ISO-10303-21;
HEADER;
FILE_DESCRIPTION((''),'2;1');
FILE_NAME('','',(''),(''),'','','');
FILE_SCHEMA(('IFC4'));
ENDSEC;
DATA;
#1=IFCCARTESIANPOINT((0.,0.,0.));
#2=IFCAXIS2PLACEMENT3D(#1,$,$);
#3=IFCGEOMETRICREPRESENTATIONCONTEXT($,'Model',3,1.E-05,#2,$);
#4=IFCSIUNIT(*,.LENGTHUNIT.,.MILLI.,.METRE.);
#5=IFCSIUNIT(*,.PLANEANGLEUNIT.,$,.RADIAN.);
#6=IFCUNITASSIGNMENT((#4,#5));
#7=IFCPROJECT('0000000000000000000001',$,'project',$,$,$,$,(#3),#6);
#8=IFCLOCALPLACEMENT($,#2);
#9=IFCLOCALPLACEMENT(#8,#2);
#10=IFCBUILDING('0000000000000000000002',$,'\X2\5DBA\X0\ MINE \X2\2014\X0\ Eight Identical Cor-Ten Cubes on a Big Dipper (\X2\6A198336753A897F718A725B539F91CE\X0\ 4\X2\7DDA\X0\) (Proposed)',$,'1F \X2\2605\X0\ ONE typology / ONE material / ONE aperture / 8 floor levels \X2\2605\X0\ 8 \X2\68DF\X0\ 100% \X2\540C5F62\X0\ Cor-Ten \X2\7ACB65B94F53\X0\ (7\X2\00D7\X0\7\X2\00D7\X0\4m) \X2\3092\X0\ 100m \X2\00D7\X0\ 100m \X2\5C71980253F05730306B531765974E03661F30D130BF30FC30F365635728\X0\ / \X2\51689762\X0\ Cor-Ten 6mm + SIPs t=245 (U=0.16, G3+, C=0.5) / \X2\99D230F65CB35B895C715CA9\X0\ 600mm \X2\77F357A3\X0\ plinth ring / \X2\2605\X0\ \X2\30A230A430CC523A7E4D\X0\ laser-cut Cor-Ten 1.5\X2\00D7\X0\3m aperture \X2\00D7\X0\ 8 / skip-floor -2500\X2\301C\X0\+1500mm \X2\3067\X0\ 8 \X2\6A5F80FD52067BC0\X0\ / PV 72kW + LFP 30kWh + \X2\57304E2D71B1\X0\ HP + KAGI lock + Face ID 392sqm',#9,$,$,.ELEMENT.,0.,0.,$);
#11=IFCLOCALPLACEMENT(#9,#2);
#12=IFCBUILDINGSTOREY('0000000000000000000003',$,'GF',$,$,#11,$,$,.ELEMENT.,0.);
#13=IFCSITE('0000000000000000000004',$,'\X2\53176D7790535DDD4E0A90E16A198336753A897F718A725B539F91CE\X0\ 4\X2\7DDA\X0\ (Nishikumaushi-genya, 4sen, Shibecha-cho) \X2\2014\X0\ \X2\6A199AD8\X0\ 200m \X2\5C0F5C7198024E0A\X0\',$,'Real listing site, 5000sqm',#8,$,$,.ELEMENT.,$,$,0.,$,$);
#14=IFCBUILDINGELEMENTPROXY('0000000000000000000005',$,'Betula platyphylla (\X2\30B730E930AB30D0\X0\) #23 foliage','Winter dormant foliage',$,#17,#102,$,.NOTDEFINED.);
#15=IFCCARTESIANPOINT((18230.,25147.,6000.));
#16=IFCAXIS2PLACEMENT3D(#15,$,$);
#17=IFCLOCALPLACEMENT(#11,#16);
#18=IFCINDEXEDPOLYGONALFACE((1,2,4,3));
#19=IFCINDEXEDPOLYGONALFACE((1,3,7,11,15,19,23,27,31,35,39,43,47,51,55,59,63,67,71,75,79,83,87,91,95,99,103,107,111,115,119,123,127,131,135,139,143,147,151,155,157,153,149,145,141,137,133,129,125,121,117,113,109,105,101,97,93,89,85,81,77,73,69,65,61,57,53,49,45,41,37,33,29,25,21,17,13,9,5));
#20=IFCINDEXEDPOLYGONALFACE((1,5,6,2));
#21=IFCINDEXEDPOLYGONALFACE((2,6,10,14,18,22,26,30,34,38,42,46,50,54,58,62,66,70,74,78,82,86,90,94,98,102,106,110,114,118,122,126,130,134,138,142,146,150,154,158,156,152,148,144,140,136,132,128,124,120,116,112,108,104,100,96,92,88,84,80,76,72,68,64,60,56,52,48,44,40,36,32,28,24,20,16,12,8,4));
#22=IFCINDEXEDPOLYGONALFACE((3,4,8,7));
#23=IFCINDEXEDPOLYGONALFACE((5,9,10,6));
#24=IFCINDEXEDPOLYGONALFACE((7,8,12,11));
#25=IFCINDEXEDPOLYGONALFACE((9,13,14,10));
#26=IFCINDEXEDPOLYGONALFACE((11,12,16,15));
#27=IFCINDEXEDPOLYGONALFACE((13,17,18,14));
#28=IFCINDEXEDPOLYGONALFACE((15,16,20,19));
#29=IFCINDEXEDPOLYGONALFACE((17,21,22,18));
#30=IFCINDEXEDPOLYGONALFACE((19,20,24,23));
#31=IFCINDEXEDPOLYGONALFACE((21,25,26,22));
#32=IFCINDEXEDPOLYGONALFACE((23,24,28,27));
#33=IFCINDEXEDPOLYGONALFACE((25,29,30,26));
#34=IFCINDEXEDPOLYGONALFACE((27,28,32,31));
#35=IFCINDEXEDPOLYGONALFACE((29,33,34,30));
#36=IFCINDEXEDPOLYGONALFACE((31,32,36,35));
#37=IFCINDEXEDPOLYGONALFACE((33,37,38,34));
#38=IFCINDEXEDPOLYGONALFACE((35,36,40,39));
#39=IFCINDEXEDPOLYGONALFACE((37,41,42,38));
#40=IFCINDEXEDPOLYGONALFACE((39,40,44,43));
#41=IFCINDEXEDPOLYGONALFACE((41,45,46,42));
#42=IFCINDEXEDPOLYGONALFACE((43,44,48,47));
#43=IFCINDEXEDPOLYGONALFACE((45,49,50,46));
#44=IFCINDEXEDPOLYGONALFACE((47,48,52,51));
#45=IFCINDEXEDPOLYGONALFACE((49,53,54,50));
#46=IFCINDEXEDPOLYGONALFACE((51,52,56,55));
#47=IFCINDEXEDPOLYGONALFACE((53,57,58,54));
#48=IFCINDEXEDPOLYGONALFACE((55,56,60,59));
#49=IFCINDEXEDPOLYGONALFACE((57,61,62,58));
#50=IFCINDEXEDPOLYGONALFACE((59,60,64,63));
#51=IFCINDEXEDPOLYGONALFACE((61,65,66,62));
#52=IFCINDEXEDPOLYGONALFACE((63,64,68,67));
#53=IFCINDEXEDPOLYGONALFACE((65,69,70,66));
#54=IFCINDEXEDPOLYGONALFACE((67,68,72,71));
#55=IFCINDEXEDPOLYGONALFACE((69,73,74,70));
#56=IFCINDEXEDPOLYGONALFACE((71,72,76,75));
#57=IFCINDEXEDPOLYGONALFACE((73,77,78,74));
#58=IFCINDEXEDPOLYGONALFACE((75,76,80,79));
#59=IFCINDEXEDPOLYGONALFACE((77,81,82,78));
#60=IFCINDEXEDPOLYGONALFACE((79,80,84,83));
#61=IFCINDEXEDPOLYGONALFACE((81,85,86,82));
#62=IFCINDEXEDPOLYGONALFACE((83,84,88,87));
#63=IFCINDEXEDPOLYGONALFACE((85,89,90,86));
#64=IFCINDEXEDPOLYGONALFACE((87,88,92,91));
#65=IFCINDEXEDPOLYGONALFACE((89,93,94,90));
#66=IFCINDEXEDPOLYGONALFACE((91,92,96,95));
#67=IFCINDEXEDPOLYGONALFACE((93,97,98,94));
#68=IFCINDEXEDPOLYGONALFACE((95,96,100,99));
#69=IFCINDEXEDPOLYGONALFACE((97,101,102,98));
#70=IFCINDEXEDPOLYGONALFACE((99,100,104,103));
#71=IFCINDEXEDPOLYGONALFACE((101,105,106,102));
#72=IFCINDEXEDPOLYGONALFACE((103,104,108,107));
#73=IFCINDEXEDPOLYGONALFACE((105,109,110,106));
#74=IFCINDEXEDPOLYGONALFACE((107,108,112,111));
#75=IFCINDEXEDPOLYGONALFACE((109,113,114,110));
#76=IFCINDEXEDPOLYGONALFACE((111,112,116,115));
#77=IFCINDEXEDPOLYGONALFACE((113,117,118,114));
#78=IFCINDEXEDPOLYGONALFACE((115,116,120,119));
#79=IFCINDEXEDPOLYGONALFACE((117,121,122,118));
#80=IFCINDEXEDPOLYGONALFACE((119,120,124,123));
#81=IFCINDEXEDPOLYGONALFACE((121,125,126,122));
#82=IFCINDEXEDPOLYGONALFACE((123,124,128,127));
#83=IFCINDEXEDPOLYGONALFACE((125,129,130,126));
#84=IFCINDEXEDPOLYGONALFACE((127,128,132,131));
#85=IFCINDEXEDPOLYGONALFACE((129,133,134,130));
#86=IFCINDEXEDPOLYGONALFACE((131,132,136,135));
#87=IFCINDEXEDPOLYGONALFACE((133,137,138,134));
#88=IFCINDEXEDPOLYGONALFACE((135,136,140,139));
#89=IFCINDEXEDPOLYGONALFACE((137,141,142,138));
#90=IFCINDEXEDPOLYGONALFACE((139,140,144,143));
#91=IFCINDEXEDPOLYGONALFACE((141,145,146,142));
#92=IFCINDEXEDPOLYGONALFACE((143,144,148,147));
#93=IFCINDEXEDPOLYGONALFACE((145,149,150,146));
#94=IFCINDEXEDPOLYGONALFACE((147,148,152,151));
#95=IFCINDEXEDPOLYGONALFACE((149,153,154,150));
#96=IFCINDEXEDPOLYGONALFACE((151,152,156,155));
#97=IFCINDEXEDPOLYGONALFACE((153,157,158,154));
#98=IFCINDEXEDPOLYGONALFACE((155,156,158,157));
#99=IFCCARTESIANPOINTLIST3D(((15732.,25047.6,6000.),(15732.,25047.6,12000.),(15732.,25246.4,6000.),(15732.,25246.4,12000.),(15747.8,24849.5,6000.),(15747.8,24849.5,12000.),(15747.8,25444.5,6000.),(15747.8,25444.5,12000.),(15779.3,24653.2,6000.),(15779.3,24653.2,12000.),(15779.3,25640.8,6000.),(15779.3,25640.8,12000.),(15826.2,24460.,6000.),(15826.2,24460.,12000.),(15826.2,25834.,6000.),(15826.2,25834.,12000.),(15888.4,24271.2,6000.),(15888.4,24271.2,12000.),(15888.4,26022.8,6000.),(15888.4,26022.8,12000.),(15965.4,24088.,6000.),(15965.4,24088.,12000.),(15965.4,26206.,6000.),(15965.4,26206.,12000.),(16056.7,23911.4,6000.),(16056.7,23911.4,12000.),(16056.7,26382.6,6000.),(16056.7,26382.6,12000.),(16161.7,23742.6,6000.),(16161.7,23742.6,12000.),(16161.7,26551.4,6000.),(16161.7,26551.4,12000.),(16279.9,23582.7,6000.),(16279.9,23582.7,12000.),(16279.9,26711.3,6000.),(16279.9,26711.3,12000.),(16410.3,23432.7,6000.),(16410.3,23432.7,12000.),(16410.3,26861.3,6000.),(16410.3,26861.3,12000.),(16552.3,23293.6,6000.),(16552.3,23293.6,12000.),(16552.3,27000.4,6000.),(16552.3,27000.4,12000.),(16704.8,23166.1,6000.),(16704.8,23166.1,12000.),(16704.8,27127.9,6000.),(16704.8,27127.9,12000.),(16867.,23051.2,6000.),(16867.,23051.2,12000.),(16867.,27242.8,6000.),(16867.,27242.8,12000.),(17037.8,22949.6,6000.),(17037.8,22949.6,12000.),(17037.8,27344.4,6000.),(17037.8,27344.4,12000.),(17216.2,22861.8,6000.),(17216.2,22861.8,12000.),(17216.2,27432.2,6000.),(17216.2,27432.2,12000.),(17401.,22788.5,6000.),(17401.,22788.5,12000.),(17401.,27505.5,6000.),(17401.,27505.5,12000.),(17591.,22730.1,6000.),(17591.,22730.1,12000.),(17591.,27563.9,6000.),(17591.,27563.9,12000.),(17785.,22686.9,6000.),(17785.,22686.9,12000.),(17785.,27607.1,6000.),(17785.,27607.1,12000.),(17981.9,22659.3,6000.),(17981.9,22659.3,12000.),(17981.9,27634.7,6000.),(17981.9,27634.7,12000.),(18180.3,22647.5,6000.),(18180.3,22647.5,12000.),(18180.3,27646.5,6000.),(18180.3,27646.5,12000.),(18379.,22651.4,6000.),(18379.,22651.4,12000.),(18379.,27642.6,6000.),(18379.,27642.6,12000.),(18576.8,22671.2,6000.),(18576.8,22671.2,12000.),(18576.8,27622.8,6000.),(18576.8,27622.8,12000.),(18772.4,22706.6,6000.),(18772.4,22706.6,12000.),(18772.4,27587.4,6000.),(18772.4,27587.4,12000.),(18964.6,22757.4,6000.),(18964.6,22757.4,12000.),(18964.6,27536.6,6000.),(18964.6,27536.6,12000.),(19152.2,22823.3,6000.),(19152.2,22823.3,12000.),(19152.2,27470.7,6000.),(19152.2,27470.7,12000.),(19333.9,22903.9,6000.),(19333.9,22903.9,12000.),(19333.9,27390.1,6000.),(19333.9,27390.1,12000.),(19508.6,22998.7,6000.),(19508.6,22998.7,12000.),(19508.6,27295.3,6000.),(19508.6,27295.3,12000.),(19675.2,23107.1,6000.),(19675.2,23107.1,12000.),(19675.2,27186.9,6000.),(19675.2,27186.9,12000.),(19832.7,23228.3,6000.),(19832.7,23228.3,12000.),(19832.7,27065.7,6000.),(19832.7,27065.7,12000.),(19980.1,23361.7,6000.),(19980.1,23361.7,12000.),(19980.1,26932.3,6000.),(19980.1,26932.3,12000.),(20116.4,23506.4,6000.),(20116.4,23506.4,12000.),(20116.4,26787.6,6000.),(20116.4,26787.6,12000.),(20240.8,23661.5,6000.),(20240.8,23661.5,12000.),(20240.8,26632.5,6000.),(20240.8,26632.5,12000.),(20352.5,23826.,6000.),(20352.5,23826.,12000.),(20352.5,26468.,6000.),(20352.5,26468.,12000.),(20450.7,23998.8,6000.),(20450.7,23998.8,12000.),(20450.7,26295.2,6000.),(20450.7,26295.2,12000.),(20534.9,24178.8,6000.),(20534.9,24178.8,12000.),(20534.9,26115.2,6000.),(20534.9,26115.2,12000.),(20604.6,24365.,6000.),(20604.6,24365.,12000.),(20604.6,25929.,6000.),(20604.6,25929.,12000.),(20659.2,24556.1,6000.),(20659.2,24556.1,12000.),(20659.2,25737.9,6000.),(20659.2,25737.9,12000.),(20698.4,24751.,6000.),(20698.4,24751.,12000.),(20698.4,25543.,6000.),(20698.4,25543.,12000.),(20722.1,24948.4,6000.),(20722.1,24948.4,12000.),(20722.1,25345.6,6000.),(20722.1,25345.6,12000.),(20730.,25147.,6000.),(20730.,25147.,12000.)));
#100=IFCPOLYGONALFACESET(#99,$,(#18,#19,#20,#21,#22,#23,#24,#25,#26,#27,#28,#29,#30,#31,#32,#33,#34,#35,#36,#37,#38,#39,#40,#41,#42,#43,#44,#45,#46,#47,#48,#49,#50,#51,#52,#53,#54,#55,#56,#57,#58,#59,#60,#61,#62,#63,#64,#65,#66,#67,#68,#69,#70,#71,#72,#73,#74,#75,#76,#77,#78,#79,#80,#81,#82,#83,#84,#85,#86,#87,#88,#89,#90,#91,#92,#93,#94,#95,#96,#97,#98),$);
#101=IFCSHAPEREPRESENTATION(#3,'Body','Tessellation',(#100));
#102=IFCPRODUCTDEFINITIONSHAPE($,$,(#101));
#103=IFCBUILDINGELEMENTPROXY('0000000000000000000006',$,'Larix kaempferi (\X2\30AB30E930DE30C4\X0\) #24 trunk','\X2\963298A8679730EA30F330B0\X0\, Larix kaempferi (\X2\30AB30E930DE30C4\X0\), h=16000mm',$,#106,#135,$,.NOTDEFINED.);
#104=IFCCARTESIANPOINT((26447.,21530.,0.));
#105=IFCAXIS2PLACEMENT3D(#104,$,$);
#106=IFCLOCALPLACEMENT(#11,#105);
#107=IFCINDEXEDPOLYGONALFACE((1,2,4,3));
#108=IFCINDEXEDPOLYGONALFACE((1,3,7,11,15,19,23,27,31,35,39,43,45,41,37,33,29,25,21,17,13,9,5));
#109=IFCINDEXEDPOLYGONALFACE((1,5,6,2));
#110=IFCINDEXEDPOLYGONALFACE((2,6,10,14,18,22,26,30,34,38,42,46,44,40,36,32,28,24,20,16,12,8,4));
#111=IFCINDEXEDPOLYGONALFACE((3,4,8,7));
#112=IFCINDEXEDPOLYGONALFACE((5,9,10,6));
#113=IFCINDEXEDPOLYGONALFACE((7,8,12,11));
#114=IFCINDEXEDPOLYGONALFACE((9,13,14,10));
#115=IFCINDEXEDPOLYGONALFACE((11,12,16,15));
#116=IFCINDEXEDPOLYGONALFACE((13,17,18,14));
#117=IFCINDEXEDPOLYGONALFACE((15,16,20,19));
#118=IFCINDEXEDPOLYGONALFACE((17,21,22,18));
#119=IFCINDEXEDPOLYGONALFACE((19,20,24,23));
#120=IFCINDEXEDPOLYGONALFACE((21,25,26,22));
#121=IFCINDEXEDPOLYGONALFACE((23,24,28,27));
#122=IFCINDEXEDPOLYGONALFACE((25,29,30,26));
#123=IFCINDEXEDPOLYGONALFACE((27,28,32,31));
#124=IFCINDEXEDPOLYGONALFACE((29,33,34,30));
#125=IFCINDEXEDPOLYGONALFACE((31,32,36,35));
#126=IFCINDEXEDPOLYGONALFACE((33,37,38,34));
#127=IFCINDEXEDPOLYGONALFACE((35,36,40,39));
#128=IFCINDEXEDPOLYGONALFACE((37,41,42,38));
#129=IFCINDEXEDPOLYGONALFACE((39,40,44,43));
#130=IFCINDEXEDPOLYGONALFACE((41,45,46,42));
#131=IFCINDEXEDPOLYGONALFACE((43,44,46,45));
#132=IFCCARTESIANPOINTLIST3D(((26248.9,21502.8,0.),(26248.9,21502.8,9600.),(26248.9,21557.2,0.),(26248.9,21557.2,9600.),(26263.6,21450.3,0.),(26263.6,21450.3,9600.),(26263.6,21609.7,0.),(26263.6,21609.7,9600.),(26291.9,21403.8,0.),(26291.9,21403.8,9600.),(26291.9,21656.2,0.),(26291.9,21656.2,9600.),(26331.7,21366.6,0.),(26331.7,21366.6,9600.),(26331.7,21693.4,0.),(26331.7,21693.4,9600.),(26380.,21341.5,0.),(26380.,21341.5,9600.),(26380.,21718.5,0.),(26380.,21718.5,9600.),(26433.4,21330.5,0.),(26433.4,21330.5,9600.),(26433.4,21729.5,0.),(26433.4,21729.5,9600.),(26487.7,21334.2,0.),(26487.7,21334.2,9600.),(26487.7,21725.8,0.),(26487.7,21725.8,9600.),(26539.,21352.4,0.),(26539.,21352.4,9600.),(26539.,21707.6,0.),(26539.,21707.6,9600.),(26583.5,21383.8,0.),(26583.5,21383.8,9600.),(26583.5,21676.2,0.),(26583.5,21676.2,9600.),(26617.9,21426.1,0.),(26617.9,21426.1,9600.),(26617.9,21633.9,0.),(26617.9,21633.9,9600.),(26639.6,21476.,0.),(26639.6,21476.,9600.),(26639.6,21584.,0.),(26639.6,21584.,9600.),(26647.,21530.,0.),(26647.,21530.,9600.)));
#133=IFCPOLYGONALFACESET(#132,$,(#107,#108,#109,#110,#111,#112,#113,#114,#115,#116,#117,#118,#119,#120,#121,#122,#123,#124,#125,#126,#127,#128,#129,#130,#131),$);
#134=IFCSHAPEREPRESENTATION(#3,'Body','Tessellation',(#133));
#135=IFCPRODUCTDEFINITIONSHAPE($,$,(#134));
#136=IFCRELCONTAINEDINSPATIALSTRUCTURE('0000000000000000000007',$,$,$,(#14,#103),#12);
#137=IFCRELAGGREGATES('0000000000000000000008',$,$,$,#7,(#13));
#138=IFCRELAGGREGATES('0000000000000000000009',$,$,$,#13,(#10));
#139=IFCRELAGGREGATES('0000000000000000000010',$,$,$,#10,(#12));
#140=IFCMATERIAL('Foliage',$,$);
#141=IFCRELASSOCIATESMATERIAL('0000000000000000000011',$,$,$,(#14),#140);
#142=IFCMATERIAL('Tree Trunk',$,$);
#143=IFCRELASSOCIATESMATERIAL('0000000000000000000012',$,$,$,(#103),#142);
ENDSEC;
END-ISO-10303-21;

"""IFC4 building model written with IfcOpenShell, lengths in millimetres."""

from ifc_helpers import new_model, si_unit, frame, origin, origin_2d, place, context, project, spatial, circle, extrude, material, element, save


model = new_model("IFC4")

# Units and contexts
model_context = context("Model", 3, precision=1e-05, world=origin())
ifc_project = project(units=[si_unit("LENGTHUNIT", "METRE", prefix="MILLI"), si_unit("PLANEANGLEUNIT", "RADIAN")], contexts=[model_context])

# Site, building, storey
site_placement = place(None, origin())
site = spatial("IfcSite", under=ifc_project, at=site_placement, Name="北海道川上郡標茶町西熊牛原野 4線 (Nishikumaushi-genya, 4sen, Shibecha-cho) — 標高 200m 小山頂上", ObjectType="Real listing site, 5000sqm", CompositionType="ELEMENT", RefElevation=0.0)
building_placement = place(site_placement, origin())
building = spatial("IfcBuilding", under=site, at=building_placement, Name="嶺 MINE — Eight Identical Cor-Ten Cubes on a Big Dipper (標茶町西熊牛原野 4線) (Proposed)", ObjectType="1F ★ ONE typology / ONE material / ONE aperture / 8 floor levels ★ 8 棟 100% 同形 Cor-Ten 立方体 (7×7×4m) を 100m × 100m 山頂台地に北斗七星パターン散在 / 全面 Cor-Ten 6mm + SIPs t=245 (U=0.16, G3+, C=0.5) / 駒ヶ岳安山岩 600mm 石垣 plinth ring / ★ アイヌ刺繍 laser-cut Cor-Ten 1.5×3m aperture × 8 / skip-floor -2500〜+1500mm で 8 機能分節 / PV 72kW + LFP 30kWh + 地中熱 HP + KAGI lock + Face ID 392sqm", CompositionType="ELEMENT", ElevationOfRefHeight=0.0, ElevationOfTerrain=0.0)
storey_placement = place(building_placement, origin())
storey = spatial("IfcBuildingStorey", under=building, at=storey_placement, Name="GF", CompositionType="ELEMENT", Elevation=0.0)

# Building element proxies
ifc_material_1 = material(Name="Tree Trunk")
ifc_material_2 = material(Name="Foliage")
proxy_1_placement = place(storey_placement, frame((18230.0, 25147.0, 6000.0)))
element("IfcBuildingElementProxy", 1, at=proxy_1_placement, inside=storey, material=ifc_material_2, Name="Betula platyphylla (シラカバ) #23 foliage", Description="Winter dormant foliage", PredefinedType="NOTDEFINED", context=model_context, shape_type="SweptSolid", body=[
    extrude(circle(Radius=2500.0, at=origin_2d()), frame((18230.0, 25147.0, 6000.0)), (0.0, 0.0, 1.0), 6000.0),
])
proxy_2_placement = place(storey_placement, frame((26447.0, 21530.0, 0.0)))
element("IfcBuildingElementProxy", 2, at=proxy_2_placement, inside=storey, material=ifc_material_1, Name="Larix kaempferi (カラマツ) #24 trunk", Description="防風林リング, Larix kaempferi (カラマツ), h=16000mm", PredefinedType="NOTDEFINED", context=model_context, shape_type="SweptSolid", body=[
    extrude(circle(Radius=200.0, at=origin_2d()), frame((26447.0, 21530.0, 0.0)), (0.0, 0.0, 1.0), 9600.0),
])

save(model, "model.ifc")
